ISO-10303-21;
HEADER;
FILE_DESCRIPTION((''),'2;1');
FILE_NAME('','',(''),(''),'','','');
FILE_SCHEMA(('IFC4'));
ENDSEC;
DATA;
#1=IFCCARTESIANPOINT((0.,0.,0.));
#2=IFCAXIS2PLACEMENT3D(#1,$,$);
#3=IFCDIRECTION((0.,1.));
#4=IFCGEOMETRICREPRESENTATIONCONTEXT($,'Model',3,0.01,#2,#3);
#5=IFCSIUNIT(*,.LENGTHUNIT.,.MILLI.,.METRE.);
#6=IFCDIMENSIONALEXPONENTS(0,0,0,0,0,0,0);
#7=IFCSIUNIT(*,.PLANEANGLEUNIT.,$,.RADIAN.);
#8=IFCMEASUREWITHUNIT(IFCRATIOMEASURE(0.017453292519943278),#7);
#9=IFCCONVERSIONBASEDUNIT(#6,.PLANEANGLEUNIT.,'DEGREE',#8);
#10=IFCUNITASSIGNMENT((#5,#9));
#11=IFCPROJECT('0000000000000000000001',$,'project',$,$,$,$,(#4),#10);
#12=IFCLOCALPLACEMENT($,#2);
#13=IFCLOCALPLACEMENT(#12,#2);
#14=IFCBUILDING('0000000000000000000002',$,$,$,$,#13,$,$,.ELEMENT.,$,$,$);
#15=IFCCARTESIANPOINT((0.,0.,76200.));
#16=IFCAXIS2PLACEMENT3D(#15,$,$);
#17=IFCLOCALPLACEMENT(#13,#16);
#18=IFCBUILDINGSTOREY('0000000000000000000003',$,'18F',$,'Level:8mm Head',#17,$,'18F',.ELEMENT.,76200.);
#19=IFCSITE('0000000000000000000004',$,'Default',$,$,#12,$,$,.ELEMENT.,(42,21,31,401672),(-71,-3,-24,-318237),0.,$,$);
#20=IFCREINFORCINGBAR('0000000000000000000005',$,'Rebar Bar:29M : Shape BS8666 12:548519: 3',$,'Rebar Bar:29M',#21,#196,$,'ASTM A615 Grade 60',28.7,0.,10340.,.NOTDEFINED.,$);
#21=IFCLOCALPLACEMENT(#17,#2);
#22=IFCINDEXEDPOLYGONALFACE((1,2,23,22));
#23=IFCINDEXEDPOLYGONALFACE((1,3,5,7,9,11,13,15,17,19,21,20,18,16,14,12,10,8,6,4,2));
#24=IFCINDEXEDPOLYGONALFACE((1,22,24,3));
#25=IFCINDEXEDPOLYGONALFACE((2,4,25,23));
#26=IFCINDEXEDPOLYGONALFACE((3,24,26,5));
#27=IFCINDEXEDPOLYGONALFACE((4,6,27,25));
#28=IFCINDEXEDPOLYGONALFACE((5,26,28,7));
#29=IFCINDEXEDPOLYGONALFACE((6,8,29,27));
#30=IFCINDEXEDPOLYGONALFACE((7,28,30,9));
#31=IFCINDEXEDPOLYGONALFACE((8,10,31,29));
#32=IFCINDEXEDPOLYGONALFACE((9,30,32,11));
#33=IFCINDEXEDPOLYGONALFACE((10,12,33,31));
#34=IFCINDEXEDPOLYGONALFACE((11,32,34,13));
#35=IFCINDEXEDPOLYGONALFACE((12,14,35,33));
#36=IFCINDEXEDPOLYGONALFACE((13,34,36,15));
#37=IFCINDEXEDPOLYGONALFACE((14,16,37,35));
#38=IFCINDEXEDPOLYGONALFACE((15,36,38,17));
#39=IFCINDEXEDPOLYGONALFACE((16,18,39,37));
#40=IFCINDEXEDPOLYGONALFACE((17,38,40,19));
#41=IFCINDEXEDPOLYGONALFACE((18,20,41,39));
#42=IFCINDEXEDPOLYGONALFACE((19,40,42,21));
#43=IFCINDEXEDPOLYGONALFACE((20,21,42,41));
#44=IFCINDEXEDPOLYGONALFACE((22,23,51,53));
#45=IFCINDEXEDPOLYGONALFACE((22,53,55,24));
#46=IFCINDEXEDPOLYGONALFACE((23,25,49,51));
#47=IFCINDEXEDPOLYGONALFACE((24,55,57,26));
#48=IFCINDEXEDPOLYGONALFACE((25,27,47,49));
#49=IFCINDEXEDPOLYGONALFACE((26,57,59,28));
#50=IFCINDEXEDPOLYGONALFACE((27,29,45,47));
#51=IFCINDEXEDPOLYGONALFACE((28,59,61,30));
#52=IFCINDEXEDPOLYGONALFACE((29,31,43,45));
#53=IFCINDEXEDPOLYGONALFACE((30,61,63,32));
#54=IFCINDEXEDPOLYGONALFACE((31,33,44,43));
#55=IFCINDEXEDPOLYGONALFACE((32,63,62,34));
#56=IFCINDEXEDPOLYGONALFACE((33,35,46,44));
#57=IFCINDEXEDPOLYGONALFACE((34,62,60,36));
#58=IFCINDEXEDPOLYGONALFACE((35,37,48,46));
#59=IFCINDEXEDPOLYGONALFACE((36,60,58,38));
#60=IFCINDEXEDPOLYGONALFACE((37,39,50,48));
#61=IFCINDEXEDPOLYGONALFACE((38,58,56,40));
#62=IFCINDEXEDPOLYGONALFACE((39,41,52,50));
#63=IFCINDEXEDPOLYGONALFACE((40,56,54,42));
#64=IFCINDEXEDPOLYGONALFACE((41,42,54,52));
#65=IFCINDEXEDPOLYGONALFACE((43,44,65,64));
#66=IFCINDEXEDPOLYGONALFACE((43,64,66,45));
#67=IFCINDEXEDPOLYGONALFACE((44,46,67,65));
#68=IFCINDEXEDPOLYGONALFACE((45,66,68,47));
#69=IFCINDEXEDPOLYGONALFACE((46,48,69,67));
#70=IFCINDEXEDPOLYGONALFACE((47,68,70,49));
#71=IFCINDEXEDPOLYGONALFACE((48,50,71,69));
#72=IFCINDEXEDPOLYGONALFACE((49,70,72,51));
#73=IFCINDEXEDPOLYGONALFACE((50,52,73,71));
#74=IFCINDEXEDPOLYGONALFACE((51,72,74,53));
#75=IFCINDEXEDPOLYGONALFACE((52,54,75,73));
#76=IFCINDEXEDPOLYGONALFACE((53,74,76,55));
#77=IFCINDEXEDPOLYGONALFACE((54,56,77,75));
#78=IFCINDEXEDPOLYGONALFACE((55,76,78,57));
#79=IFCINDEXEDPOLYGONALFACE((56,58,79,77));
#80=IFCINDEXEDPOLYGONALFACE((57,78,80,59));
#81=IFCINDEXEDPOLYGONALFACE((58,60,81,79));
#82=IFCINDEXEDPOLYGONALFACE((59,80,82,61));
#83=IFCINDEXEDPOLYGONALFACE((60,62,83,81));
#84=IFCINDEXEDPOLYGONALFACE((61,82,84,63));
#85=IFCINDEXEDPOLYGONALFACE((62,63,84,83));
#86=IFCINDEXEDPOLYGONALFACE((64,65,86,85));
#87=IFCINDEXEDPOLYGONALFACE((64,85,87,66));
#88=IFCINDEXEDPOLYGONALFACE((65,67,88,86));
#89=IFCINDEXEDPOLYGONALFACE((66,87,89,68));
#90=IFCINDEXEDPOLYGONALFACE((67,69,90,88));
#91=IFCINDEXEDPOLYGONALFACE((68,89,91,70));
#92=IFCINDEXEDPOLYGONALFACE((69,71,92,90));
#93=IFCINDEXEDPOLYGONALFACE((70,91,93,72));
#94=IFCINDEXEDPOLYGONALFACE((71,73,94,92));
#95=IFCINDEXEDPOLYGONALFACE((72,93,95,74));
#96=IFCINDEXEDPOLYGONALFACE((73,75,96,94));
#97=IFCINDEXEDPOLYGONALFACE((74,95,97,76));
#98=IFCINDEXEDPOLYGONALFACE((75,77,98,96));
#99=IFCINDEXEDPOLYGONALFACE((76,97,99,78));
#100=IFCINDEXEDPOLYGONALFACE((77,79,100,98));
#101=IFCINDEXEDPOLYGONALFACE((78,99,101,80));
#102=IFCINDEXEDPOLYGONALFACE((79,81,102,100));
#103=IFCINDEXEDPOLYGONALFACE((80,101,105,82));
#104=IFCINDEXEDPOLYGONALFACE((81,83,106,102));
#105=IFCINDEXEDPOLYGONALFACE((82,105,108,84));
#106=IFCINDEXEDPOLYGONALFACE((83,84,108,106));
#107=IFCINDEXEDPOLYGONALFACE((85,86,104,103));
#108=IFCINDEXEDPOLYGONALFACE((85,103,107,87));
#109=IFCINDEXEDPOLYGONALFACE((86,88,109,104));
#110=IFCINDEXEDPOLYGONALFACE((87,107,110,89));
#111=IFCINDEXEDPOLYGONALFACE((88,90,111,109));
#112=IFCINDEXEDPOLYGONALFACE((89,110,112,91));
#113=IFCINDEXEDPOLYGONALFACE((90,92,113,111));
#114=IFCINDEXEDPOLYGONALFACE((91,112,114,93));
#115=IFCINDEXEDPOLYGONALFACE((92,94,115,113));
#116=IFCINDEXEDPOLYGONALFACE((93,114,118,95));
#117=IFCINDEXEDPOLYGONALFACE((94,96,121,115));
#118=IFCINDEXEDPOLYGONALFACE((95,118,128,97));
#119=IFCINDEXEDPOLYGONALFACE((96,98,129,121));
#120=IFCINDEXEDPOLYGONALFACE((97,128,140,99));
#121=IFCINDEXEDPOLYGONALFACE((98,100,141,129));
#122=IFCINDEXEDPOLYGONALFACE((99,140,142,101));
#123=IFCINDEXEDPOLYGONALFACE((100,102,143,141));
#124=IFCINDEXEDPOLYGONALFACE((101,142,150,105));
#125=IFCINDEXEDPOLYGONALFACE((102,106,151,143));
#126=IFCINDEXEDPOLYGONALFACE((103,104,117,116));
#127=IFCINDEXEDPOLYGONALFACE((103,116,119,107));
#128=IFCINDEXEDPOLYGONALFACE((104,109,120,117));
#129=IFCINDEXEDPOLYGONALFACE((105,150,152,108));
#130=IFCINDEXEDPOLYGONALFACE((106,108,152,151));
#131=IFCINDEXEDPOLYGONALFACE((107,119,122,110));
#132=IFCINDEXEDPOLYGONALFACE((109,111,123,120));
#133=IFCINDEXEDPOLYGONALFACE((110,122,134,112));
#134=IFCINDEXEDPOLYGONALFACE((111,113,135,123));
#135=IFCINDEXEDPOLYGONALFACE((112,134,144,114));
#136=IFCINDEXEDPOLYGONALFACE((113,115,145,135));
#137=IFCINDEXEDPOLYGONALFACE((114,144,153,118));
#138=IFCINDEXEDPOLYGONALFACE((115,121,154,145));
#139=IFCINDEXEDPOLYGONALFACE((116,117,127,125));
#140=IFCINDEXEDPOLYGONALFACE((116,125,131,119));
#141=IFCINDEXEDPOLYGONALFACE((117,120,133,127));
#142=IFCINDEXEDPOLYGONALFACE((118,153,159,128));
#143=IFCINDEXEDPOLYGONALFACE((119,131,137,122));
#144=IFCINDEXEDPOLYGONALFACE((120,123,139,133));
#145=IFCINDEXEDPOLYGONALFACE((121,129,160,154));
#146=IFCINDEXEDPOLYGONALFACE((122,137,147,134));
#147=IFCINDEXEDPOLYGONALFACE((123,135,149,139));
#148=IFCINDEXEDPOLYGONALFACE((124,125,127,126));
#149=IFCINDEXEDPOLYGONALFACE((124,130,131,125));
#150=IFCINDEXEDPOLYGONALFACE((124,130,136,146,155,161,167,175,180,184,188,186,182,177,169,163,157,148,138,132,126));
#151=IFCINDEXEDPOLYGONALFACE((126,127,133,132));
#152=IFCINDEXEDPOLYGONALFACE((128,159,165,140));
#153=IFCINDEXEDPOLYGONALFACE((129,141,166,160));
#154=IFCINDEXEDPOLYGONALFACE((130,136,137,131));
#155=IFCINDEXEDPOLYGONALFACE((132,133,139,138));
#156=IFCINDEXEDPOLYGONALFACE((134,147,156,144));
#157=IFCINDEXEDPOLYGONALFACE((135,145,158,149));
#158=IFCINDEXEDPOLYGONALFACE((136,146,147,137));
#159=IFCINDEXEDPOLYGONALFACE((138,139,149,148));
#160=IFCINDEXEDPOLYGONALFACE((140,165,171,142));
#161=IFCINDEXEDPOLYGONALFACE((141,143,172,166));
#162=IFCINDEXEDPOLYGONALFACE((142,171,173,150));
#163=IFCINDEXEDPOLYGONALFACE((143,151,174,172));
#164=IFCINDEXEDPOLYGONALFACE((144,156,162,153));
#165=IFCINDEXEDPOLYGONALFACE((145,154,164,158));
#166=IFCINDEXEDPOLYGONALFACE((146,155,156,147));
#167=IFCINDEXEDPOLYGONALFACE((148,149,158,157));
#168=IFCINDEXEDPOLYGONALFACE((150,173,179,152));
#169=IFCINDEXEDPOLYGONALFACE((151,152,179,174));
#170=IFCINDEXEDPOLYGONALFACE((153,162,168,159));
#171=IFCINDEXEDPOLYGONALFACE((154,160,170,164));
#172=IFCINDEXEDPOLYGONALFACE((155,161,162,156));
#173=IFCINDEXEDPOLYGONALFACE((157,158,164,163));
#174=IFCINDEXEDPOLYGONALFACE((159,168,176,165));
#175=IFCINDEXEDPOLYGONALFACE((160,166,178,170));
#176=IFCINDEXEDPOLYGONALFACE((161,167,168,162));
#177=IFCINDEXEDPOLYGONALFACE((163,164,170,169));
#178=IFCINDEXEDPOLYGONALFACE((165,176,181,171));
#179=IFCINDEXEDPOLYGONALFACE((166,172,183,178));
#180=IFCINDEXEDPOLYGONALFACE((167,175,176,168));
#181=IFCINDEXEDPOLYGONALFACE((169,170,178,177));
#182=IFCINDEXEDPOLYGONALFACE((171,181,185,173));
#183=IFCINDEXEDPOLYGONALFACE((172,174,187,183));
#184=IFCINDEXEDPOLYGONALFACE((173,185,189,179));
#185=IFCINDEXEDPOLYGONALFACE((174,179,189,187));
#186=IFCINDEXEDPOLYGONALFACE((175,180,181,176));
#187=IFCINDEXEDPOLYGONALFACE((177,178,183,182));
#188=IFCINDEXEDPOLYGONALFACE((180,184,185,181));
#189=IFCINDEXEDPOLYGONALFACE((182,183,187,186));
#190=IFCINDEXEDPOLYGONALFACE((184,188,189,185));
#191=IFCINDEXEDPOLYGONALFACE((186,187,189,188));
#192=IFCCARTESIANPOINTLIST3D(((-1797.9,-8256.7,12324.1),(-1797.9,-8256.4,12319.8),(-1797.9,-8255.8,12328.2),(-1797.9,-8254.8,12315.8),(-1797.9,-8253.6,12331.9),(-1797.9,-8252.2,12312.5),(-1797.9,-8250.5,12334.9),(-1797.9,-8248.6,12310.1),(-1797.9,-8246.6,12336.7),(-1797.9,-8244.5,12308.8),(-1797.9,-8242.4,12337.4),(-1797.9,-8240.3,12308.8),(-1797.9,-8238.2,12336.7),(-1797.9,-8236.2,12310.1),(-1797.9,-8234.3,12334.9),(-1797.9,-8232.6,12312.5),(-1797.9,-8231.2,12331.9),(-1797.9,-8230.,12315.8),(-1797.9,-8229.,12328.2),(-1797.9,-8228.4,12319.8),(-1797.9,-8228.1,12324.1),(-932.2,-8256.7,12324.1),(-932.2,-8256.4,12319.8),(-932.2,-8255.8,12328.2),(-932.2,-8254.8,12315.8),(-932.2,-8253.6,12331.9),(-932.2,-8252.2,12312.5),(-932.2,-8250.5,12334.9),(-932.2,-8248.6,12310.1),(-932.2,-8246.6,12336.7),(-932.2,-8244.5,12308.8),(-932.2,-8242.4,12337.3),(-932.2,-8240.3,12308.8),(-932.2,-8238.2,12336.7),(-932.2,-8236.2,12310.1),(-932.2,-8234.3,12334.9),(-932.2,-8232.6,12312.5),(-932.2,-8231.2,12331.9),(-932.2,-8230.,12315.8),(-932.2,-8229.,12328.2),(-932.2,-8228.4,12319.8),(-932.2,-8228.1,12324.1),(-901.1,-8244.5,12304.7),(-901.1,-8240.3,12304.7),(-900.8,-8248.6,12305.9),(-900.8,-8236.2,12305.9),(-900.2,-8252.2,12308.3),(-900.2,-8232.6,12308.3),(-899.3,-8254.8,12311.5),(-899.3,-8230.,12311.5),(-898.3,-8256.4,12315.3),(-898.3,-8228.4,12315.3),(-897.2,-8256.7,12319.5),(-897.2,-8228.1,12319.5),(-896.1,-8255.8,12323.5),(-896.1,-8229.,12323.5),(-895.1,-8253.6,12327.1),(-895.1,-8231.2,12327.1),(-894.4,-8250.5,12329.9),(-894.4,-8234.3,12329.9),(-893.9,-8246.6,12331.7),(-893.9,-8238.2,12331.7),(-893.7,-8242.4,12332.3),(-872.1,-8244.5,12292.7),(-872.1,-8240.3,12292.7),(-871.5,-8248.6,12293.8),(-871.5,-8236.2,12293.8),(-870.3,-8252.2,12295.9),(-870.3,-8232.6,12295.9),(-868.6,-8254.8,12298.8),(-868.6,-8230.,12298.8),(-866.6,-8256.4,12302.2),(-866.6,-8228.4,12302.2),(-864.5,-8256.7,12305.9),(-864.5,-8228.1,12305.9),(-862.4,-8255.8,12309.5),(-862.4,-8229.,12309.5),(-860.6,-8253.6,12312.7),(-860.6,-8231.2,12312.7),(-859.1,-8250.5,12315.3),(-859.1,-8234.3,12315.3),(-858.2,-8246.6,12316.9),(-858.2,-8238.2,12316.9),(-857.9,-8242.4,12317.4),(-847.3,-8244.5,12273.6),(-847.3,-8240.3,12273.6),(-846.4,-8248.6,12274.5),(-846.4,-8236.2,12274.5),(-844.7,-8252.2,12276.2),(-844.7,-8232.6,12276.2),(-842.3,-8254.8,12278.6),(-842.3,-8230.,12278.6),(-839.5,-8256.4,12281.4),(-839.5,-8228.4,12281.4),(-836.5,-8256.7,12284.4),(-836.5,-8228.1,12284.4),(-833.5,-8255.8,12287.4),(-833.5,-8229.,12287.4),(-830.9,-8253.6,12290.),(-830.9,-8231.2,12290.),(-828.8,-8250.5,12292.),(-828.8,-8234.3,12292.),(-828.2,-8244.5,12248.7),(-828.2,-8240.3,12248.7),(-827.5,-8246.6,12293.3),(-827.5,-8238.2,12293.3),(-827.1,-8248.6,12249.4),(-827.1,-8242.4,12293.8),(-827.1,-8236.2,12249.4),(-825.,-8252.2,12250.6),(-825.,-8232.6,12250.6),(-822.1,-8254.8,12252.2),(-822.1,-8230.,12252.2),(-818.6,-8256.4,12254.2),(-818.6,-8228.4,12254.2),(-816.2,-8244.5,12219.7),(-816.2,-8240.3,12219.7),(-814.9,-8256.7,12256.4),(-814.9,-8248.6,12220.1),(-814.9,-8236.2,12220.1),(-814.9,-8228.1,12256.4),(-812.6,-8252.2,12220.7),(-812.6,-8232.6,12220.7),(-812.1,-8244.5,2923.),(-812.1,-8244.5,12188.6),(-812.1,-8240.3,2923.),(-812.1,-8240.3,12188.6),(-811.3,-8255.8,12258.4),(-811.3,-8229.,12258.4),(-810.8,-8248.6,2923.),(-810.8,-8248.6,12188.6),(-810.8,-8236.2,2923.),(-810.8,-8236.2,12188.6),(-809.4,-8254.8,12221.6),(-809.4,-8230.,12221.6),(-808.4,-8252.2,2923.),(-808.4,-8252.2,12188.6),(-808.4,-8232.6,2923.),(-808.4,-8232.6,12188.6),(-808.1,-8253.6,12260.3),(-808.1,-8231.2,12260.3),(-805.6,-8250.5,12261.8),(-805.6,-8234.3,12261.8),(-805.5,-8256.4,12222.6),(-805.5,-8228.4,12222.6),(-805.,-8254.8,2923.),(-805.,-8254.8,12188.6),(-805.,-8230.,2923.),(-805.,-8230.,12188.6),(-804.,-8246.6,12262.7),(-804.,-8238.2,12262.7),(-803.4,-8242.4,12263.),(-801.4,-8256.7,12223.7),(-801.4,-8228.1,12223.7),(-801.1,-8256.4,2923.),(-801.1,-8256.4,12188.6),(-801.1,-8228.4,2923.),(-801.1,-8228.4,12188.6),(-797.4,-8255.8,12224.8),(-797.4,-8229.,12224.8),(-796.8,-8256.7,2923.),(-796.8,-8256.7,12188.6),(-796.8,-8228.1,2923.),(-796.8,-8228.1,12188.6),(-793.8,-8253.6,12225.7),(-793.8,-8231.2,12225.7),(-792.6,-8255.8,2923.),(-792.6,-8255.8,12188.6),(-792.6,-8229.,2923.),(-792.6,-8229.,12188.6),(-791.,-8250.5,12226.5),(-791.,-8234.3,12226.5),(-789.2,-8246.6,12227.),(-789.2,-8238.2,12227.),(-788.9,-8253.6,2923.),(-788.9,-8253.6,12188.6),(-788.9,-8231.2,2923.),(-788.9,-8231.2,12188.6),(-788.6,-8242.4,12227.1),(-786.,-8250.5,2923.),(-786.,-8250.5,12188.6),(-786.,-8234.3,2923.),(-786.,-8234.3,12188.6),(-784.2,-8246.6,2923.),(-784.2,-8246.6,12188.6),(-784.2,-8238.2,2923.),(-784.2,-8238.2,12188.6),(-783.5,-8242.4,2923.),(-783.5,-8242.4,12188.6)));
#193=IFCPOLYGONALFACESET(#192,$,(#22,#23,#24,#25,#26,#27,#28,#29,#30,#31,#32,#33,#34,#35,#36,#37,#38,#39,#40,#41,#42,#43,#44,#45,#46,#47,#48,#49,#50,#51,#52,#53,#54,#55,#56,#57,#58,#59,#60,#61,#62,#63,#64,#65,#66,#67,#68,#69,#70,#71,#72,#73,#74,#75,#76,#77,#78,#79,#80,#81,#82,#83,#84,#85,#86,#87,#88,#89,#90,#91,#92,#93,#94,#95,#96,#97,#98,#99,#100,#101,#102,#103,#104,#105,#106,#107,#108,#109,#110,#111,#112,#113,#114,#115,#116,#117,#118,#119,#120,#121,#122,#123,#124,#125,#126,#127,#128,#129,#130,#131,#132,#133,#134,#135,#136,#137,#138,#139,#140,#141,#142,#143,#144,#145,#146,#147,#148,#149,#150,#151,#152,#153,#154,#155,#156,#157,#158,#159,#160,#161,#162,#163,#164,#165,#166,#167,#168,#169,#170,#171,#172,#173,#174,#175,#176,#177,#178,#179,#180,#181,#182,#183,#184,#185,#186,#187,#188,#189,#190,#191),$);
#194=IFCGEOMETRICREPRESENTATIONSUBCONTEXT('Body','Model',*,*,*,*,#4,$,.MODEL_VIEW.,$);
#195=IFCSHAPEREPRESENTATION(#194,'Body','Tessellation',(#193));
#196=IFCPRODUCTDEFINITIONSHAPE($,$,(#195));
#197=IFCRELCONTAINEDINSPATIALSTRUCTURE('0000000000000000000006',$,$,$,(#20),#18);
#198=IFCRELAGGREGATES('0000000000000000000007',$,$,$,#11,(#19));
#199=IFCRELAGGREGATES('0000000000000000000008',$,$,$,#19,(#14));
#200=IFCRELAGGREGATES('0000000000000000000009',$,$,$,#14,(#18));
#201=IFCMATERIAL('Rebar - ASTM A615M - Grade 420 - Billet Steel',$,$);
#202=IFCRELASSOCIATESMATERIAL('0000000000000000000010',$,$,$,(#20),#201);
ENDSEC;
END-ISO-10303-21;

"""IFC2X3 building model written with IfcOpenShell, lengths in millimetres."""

from ifc_helpers import new_model, entity, si_unit, converted_unit, direction, frame, origin, place, context, subcontext, project, spatial, material, element, save


model = new_model("IFC2X3")

# Units and contexts
model_context = context("Model", 3, precision=0.01, world=origin(), true_north=direction((0.0, 1.0)))
body_context = subcontext(model_context, "Body", "Model", "MODEL_VIEW")
ifc_project = project(units=[si_unit("LENGTHUNIT", "METRE", prefix="MILLI"), converted_unit("PLANEANGLEUNIT", "DEGREE", entity("IfcRatioMeasure", 0.017453292519943278), si_unit("PLANEANGLEUNIT", "RADIAN"), dimensions=[0, 0, 0, 0, 0, 0, 0])], contexts=[model_context])

# Site, building, storey
site_placement = place(None, origin())
site = spatial("IfcSite", under=ifc_project, at=site_placement, Name="Default", CompositionType="ELEMENT", RefLatitude=(42, 21, 31, 401672), RefLongitude=(-71, -3, -24, -318237), RefElevation=0.0)
building_placement = place(site_placement, origin())
building = spatial("IfcBuilding", under=site, at=building_placement, CompositionType="ELEMENT")
storey_placement = place(building_placement, frame((0.0, 0.0, 76200.0)))
storey = spatial("IfcBuildingStorey", under=building, at=storey_placement, Name="18F", ObjectType="Level:8mm Head", LongName="18F", CompositionType="ELEMENT", Elevation=76200.0)

# Reinforcing bar
ifc_material_1 = material(Name="Rebar - ASTM A615M - Grade 420 - Billet Steel")
reinforcing_bar_1_placement = place(storey_placement, origin())
element("IfcReinforcingBar", 1, at=reinforcing_bar_1_placement, inside=storey, material=ifc_material_1, Name="Rebar Bar:29M : Shape BS8666 12:548519: 3", SteelGrade="ASTM A615 Grade 60", ObjectType="Rebar Bar:29M", BarLength=10340.0, BarRole="NOTDEFINED", CrossSectionArea=0.0, NominalDiameter=28.7, context=body_context, shape_type="AdvancedSweptSolid", body=[
    entity("IfcSweptDiskSolid", entity("IfcCompositeCurve", [entity("IfcCompositeCurveSegment", "CONTINUOUS", True, entity("IfcPolyline", [entity("IfcCartesianPoint", [-797.9, -8242.4, 2923.0]), entity("IfcCartesianPoint", [-797.9, -8242.4, 12188.6])])), entity("IfcCompositeCurveSegment", "CONTINUOUS", True, entity("IfcTrimmedCurve", entity("IfcCircle", entity("IfcAxis2Placement3D", entity("IfcCartesianPoint", [-932.2, -8242.4, 12188.6]), entity("IfcDirection", [0.0, -1.0, 0.0]), entity("IfcDirection", [0.0, 0.0, 1.0])), 134.3), [entity("IfcParameterValue", 270.0)], [entity("IfcParameterValue", 360.0)], True, "PARAMETER")), entity("IfcCompositeCurveSegment", "CONTINUOUS", True, entity("IfcPolyline", [entity("IfcCartesianPoint", [-932.2, -8242.4, 12323.0]), entity("IfcCartesianPoint", [-1797.9, -8242.4, 12323.0])]))], False), 14.3, None, 0.0, 92.0),
])

save(model, "model.ifc")
